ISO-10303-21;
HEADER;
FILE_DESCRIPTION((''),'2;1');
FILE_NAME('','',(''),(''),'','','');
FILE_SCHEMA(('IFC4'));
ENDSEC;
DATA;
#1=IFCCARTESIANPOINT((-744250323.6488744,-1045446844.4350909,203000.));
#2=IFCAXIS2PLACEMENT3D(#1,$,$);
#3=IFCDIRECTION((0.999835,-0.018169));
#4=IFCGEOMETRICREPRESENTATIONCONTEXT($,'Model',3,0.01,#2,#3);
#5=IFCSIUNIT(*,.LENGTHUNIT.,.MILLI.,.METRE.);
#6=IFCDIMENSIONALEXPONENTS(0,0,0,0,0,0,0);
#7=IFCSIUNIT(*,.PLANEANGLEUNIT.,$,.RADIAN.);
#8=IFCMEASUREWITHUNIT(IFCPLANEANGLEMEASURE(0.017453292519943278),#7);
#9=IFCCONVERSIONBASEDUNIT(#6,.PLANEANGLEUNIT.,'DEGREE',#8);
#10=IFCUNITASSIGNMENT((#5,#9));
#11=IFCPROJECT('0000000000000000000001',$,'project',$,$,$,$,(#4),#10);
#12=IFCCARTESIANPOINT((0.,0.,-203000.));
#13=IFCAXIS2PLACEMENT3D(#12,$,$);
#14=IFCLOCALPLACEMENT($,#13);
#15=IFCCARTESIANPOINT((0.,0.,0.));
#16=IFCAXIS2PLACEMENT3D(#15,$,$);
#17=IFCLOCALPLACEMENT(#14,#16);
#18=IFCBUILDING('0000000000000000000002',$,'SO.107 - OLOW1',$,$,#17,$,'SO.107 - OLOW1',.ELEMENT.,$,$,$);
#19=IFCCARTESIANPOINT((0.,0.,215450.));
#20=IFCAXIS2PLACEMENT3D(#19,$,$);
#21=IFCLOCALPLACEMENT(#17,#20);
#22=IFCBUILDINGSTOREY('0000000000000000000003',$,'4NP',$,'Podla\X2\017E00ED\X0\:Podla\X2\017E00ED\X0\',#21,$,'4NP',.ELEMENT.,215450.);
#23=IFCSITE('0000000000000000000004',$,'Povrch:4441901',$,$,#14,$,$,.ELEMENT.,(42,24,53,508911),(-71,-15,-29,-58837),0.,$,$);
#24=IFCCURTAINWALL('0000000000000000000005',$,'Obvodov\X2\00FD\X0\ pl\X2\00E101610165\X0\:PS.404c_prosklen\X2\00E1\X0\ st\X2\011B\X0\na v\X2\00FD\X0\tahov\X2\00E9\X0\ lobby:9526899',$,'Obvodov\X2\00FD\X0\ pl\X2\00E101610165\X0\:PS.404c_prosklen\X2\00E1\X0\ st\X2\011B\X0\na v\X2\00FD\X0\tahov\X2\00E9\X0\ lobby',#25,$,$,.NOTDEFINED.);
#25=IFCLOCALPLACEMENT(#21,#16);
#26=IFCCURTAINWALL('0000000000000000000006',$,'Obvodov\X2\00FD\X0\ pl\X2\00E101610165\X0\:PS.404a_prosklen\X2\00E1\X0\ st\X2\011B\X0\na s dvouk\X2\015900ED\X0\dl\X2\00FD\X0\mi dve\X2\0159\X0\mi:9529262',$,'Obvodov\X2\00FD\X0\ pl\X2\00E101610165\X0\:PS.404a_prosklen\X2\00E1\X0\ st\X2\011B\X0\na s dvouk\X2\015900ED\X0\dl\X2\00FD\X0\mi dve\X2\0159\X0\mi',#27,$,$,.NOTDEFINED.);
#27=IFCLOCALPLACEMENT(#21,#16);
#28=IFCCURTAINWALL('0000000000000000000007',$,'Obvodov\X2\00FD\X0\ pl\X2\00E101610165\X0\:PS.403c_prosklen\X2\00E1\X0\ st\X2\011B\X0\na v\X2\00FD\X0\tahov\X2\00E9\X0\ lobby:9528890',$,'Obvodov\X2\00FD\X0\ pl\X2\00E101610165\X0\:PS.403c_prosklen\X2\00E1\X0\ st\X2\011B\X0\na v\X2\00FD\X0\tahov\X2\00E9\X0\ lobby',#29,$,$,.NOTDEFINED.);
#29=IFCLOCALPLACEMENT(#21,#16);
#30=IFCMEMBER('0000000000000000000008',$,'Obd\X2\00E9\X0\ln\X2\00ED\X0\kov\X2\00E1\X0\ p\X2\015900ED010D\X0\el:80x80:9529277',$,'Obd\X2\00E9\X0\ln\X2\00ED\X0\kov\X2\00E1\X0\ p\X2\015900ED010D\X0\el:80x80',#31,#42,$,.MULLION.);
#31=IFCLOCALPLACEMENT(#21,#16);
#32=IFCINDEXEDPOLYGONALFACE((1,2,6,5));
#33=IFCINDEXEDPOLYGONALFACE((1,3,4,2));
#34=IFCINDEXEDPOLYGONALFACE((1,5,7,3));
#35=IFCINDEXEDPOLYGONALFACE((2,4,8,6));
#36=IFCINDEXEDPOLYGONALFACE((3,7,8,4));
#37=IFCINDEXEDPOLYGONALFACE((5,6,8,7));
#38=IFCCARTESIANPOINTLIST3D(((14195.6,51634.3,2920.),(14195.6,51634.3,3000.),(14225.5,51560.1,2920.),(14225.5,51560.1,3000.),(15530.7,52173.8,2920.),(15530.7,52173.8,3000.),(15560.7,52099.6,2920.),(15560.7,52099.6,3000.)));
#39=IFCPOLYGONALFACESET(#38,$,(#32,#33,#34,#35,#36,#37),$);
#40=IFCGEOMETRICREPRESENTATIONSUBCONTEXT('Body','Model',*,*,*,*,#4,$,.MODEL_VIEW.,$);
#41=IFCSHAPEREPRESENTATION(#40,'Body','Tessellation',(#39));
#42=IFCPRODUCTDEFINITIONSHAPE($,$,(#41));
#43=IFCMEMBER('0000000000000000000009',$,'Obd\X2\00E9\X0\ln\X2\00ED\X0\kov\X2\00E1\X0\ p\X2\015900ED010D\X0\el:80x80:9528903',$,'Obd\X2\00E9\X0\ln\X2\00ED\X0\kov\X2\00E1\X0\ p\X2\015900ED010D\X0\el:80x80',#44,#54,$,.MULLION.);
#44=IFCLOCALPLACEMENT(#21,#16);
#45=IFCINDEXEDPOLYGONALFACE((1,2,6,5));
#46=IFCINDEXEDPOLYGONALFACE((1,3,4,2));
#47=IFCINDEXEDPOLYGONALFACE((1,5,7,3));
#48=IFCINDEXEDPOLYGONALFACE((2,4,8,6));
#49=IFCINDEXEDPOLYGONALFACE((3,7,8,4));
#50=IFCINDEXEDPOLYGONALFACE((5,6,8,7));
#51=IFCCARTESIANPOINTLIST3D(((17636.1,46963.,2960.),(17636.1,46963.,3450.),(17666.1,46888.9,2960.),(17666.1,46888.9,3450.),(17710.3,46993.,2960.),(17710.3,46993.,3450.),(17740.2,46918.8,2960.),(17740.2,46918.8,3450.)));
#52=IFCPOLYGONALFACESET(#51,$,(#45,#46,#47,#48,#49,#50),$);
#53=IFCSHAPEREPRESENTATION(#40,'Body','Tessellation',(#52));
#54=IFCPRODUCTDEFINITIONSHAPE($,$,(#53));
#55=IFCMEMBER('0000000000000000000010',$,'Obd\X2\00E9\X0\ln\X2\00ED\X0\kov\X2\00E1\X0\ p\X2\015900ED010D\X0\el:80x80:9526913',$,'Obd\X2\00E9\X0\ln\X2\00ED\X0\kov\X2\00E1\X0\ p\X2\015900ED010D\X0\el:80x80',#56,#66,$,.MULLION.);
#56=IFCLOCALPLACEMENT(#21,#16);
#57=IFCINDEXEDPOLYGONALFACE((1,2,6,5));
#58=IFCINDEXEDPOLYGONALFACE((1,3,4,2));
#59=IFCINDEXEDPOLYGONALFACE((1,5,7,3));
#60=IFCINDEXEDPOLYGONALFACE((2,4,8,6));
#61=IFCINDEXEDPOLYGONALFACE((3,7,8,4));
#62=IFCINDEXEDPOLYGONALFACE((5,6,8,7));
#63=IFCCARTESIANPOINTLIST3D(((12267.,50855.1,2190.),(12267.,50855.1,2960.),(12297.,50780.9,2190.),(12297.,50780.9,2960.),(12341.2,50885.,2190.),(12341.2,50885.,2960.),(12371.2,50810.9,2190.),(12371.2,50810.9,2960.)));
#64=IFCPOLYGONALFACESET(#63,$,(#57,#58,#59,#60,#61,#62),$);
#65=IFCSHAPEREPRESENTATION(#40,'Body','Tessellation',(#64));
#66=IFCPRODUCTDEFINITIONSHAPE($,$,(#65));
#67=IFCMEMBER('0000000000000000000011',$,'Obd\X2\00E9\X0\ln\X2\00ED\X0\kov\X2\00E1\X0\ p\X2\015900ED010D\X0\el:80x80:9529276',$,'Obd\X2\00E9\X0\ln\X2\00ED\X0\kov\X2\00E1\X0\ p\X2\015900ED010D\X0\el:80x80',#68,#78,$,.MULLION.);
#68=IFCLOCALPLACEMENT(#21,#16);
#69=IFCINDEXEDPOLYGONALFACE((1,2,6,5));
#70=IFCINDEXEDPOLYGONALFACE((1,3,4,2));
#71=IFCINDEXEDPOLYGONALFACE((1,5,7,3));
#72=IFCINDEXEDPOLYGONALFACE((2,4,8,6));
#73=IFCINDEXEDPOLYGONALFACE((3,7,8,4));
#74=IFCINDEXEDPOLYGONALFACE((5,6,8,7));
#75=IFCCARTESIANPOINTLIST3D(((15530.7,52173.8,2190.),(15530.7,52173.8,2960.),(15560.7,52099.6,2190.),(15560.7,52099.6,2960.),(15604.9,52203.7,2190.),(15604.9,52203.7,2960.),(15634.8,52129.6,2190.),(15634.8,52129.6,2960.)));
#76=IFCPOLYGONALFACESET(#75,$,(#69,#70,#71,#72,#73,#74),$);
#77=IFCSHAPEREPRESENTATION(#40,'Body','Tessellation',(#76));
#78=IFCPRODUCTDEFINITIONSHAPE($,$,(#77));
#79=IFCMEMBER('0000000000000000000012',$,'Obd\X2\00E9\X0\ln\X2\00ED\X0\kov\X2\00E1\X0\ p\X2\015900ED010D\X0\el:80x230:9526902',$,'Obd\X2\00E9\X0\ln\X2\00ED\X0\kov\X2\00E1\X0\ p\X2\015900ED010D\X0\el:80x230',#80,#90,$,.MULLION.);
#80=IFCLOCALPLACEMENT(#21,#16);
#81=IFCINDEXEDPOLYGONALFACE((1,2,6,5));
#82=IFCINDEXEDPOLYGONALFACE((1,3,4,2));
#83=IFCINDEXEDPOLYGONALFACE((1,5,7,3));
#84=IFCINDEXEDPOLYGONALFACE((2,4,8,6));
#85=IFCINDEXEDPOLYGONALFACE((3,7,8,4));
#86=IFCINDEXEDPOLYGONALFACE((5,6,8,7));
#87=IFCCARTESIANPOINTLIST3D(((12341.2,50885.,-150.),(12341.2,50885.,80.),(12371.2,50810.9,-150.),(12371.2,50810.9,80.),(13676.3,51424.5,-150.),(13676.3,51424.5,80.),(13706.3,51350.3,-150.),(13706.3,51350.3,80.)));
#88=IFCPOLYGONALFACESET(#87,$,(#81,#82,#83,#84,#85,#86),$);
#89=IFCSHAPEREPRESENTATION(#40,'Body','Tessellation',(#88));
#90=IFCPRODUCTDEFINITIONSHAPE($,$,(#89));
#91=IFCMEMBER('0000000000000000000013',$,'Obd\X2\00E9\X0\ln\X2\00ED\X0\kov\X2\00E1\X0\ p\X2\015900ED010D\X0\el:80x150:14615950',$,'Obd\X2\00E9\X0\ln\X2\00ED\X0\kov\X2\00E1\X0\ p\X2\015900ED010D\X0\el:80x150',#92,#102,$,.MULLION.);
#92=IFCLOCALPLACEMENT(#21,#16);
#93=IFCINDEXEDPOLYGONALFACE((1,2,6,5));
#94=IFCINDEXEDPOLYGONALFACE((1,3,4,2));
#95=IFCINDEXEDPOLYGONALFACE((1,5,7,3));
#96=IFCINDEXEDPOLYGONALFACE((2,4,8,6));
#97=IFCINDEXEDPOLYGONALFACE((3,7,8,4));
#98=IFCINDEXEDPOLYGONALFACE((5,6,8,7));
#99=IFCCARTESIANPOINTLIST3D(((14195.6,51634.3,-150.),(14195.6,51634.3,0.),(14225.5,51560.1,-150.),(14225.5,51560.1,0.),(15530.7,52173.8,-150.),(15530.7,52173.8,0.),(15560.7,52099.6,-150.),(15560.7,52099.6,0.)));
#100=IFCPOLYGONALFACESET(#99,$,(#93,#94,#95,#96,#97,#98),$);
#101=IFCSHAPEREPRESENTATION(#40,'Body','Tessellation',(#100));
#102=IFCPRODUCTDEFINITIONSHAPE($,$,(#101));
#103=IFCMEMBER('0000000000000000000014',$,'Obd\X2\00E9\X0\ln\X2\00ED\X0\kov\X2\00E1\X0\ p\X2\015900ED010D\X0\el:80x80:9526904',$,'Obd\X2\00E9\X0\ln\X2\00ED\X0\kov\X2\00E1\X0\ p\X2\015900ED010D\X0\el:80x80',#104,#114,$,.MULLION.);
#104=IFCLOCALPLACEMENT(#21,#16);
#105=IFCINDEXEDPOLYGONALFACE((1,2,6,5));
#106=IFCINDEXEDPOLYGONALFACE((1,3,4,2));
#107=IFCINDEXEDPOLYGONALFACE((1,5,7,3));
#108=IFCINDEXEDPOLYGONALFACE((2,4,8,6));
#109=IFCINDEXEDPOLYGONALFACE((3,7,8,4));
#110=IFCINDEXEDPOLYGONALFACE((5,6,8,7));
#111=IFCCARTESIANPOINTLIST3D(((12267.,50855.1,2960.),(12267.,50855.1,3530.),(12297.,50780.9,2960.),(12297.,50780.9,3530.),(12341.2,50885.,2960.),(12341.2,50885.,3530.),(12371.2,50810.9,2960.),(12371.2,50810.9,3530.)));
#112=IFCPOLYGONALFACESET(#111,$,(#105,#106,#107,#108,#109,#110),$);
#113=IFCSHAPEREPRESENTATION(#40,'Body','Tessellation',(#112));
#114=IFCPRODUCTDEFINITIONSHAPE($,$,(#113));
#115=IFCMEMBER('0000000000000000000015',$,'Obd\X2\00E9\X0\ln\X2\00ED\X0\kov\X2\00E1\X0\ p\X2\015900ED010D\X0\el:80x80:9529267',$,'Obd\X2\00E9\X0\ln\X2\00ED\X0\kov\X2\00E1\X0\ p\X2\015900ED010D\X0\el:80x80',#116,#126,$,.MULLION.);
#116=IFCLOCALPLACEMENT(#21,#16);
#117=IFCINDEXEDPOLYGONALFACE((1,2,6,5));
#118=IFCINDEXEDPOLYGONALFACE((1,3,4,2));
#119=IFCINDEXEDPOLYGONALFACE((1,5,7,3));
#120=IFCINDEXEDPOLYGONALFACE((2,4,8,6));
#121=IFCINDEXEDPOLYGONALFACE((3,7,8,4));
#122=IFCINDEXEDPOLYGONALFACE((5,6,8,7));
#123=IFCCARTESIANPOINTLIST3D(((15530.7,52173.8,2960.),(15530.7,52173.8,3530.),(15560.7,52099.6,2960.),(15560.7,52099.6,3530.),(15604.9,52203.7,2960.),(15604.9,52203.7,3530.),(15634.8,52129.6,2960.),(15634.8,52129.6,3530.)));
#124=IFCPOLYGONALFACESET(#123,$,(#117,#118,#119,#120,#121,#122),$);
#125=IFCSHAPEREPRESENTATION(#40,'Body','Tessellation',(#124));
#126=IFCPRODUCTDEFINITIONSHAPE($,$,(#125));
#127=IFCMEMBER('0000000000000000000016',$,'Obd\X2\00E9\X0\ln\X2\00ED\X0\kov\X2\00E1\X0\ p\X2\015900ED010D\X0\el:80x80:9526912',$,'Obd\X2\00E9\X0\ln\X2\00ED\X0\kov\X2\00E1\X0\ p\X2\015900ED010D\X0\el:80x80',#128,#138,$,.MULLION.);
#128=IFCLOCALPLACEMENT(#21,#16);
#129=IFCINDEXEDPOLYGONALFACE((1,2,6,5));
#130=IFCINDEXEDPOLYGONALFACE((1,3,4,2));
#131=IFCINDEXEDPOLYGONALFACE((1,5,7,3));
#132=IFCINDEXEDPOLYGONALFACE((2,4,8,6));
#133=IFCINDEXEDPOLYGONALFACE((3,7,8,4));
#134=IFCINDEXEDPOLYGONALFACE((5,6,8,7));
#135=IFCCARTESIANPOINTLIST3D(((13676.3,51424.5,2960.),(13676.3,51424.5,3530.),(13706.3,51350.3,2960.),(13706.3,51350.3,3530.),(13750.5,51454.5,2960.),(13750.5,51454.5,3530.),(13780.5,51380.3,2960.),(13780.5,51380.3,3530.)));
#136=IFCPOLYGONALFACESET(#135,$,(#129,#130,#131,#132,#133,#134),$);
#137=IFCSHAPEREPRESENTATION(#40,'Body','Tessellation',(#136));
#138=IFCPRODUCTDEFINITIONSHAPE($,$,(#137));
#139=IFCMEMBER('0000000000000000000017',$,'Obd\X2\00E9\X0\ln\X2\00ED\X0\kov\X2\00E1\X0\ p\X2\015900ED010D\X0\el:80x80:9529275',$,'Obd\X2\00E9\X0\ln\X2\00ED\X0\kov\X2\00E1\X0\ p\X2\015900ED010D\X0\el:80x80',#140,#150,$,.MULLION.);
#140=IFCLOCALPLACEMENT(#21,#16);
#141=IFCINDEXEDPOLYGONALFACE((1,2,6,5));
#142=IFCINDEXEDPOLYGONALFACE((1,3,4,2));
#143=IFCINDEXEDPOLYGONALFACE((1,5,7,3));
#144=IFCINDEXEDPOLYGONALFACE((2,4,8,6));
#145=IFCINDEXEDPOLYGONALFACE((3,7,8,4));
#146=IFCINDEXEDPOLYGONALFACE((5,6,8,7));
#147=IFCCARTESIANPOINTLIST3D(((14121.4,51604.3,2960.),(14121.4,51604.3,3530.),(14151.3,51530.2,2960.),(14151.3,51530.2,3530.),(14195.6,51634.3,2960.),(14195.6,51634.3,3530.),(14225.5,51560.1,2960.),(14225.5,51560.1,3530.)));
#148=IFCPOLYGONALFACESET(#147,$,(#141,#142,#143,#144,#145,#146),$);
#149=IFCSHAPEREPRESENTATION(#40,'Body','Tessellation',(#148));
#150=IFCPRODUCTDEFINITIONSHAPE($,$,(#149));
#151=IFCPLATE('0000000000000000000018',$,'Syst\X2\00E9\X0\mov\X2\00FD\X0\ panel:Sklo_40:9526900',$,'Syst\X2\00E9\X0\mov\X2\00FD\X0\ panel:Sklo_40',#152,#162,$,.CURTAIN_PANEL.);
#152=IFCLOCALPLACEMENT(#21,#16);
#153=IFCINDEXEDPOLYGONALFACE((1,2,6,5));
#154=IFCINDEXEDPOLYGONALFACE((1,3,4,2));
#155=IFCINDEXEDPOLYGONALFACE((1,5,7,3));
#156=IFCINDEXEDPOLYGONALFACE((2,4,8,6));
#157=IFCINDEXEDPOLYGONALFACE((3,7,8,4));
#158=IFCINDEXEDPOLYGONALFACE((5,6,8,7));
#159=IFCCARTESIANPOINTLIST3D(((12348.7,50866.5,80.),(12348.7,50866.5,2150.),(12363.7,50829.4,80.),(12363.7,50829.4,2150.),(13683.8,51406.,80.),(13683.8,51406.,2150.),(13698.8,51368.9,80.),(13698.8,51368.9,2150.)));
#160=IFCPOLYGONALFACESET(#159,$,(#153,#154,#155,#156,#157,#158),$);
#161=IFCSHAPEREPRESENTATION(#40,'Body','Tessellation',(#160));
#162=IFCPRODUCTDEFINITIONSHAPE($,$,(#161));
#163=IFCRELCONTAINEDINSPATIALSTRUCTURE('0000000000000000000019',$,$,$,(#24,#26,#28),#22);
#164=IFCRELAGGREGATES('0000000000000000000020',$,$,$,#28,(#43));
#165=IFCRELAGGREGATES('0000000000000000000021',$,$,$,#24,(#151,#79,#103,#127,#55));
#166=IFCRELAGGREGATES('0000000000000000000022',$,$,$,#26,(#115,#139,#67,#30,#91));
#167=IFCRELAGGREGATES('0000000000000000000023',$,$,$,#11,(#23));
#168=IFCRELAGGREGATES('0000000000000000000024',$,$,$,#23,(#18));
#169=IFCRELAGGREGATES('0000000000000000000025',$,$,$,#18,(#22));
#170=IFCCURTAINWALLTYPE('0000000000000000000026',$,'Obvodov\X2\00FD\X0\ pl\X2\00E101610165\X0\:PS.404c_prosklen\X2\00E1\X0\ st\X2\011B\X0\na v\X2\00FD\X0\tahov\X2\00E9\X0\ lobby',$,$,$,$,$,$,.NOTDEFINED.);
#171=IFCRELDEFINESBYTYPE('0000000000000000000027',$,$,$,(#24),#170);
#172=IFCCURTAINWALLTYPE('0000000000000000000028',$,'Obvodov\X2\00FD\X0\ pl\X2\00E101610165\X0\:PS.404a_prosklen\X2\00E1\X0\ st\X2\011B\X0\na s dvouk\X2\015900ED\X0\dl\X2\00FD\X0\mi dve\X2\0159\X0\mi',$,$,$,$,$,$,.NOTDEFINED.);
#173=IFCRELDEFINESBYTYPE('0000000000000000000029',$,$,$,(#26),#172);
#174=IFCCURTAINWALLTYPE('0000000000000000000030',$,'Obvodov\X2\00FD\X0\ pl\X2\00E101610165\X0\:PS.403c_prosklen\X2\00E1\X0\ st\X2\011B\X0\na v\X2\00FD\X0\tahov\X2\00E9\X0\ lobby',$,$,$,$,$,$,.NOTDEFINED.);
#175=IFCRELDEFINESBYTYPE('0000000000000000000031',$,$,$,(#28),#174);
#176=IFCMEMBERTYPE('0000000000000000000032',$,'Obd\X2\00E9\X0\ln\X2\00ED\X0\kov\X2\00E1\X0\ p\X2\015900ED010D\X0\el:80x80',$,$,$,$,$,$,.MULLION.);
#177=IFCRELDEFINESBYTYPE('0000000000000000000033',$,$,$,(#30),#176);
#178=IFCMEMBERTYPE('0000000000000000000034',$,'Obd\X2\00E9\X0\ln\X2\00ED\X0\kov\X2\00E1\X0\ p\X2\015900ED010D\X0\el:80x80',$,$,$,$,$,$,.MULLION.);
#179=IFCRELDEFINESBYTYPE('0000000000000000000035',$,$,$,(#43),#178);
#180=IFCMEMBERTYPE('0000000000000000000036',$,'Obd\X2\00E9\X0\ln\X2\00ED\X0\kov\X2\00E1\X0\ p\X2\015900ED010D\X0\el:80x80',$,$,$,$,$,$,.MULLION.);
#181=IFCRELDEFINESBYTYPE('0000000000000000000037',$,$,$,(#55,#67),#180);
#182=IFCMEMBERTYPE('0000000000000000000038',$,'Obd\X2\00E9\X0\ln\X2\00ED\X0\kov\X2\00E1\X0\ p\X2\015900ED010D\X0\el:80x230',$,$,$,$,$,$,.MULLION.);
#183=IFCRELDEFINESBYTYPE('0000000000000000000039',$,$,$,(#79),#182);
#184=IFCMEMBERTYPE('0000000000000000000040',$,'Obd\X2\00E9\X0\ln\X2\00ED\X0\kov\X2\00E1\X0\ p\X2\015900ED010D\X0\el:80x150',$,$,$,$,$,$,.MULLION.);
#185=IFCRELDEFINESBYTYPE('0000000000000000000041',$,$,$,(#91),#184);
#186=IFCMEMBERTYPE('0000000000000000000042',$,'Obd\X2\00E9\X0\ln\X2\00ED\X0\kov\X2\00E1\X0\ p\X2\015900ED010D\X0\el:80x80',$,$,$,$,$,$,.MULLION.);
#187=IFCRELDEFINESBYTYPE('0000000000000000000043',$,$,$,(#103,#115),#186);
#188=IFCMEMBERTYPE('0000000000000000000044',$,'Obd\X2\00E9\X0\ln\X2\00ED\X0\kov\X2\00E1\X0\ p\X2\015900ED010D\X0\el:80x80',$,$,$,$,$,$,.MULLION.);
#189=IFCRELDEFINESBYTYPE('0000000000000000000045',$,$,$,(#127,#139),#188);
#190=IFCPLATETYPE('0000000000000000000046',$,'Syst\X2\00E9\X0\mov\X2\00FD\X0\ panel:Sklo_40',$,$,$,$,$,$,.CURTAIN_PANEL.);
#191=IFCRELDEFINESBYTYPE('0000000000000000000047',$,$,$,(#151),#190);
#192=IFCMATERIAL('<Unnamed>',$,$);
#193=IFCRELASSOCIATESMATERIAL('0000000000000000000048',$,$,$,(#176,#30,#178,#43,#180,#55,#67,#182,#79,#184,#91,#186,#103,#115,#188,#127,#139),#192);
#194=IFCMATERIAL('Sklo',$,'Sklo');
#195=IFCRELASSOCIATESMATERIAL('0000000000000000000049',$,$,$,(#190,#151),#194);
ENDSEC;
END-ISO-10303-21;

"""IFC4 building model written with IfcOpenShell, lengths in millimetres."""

from ifc_helpers import new_model, entity, si_unit, converted_unit, direction, frame, origin, place, context, subcontext, project, spatial, indexed_curve, outline, extrude, source, transform, mapped, material, type_object, type_shapes, element, aggregate, save


model = new_model("IFC4")

# Units and contexts
model_context = context("Model", 3, precision=0.01, world=frame((-744250323.6488744, -1045446844.4350909, 203000.0)), true_north=direction((0.999835, -0.018169)))
body_context = subcontext(model_context, "Body", "Model", "MODEL_VIEW")
ifc_project = project(units=[si_unit("LENGTHUNIT", "METRE", prefix="MILLI"), converted_unit("PLANEANGLEUNIT", "DEGREE", entity("IfcPlaneAngleMeasure", 0.017453292519943278), si_unit("PLANEANGLEUNIT", "RADIAN"), dimensions=[0, 0, 0, 0, 0, 0, 0])], contexts=[model_context])

# Site, building, storey
site_placement = place(None, frame((0.0, 0.0, -203000.0)))
site = spatial("IfcSite", under=ifc_project, at=site_placement, Name="Povrch:4441901", CompositionType="ELEMENT", RefLatitude=(42, 24, 53, 508911), RefLongitude=(-71, -15, -29, -58837), RefElevation=0.0)
building_placement = place(site_placement, origin())
building = spatial("IfcBuilding", under=site, at=building_placement, Name="SO.107 - OLOW1", LongName="SO.107 - OLOW1", CompositionType="ELEMENT")
storey_placement = place(building_placement, frame((0.0, 0.0, 215450.0)))
storey = spatial("IfcBuildingStorey", under=building, at=storey_placement, Name="4NP", ObjectType="Podlaží:Podlaží", LongName="4NP", CompositionType="ELEMENT", Elevation=215450.0)

# Curtain walls
curtain_wall_type_1 = type_object("IfcCurtainWallType", Name="Obvodový plášť:PS.404c_prosklená stěna výtahové lobby", PredefinedType="NOTDEFINED")
curtain_wall_1_placement = place(storey_placement, frame((0.0, 0.0, -215450.0)))
curtain_wall_1 = element("IfcCurtainWall", 1, at=curtain_wall_1_placement, inside=storey, type_object=curtain_wall_type_1, Name="Obvodový plášť:PS.404c_prosklená stěna výtahové lobby:9526899", ObjectType="Obvodový plášť:PS.404c_prosklená stěna výtahové lobby", PredefinedType="NOTDEFINED")
ifc_material_1 = material(Name="<Unnamed>")
curtain_wall_type_2 = type_object("IfcCurtainWallType", Name="Obvodový plášť:PS.404a_prosklená stěna s dvoukřídlými dveřmi", PredefinedType="NOTDEFINED")
curtain_wall_2_placement = place(storey_placement, frame((0.0, 0.0, -215450.0)))
curtain_wall_2 = element("IfcCurtainWall", 2, at=curtain_wall_2_placement, inside=storey, type_object=curtain_wall_type_2, Name="Obvodový plášť:PS.404a_prosklená stěna s dvoukřídlými dveřmi:9529262", ObjectType="Obvodový plášť:PS.404a_prosklená stěna s dvoukřídlými dveřmi", PredefinedType="NOTDEFINED")

# Curtain wall
curtain_wall_type_3 = type_object("IfcCurtainWallType", Name="Obvodový plášť:PS.403c_prosklená stěna výtahové lobby", PredefinedType="NOTDEFINED")
curtain_wall_3_placement = place(storey_placement, frame((0.0, 0.0, -215450.0)))
curtain_wall_3 = element("IfcCurtainWall", 3, at=curtain_wall_3_placement, inside=storey, type_object=curtain_wall_type_3, Name="Obvodový plášť:PS.403c_prosklená stěna výtahové lobby:9528890", ObjectType="Obvodový plášť:PS.403c_prosklená stěna výtahové lobby", PredefinedType="NOTDEFINED")

# Members
member_type_1 = type_object("IfcMemberType", Name="Obdélníková příčel:80x80", PredefinedType="MULLION", material=ifc_material_1)
shared_shape_1 = source(origin(), body_context, "Body", "SweptSolid", [
    extrude(outline(indexed_curve([(-40.0, -40.0), (40.0, -40.0), (40.0, 40.0), (-40.0, 40.0), (-40.0, -40.0)], self_intersect=False)), frame((0.0, 0.0, -1440.0), z_axis=(0.0, 0.0, 1.0), x_axis=(-1.0, 0.0, 0.0)), (0.0, 0.0, 1.0), 1440.0),
])
type_shapes(member_type_1, [shared_shape_1])
member_1_placement = place(curtain_wall_2_placement, frame((14210.5, 51597.2, 218410.0), z_axis=(-0.927176, -0.374626, 0.0), x_axis=(0.0, 0.0, 1.0)))
member_1 = element("IfcMember", 4, at=member_1_placement, type_object=member_type_1, material=ifc_material_1, Name="Obdélníková příčel:80x80:9529277", ObjectType="Obdélníková příčel:80x80", PredefinedType="MULLION", context=body_context, shape_type="MappedRepresentation", body=[
    mapped(shared_shape_1, transform((0.0, 0.0, 0.0), scale=1.0)),
])
member_type_2 = type_object("IfcMemberType", Name="Obdélníková příčel:80x80", PredefinedType="MULLION", material=ifc_material_1)
shared_shape_2 = source(origin(), body_context, "Body", "SweptSolid", [
    extrude(outline(indexed_curve([(-40.0, -40.0), (40.0, -40.0), (40.0, 40.0), (-40.0, 40.0), (-40.0, -40.0)], self_intersect=False)), frame((-40.0, 0.0, -490.0), z_axis=(0.0, 0.0, 1.0), x_axis=(-1.0, 0.0, 0.0)), (0.0, 0.0, 1.0), 490.0),
])
type_shapes(member_type_2, [shared_shape_2])
member_2_placement = place(curtain_wall_3_placement, frame((17725.2, 46955.9, 218410.0), z_axis=(0.0, 0.0, -1.0), x_axis=(0.927176, 0.374626, 0.0)))
member_2 = element("IfcMember", 5, at=member_2_placement, type_object=member_type_2, material=ifc_material_1, Name="Obdélníková příčel:80x80:9528903", ObjectType="Obdélníková příčel:80x80", PredefinedType="MULLION", context=body_context, shape_type="MappedRepresentation", body=[
    mapped(shared_shape_2, transform((0.0, 0.0, 0.0), scale=1.0)),
])
aggregate(curtain_wall_3, [member_2])
member_type_3 = type_object("IfcMemberType", Name="Obdélníková příčel:80x80", PredefinedType="MULLION", material=ifc_material_1)
shared_shape_3 = source(origin(), body_context, "Body", "SweptSolid", [
    extrude(outline(indexed_curve([(-40.0, -40.0), (40.0, -40.0), (40.0, 40.0), (-40.0, 40.0), (-40.0, -40.0)], self_intersect=False)), frame((-40.0, 0.0, -770.0), z_axis=(0.0, 0.0, 1.0), x_axis=(-1.0, 0.0, 0.0)), (0.0, 0.0, 1.0), 770.0),
])
type_shapes(member_type_3, [shared_shape_3])
member_3_placement = place(curtain_wall_1_placement, frame((12282.0, 50818.0, 218410.0), z_axis=(0.0, 0.0, 1.0), x_axis=(-0.927176, -0.374626, 0.0)))
member_3 = element("IfcMember", 6, at=member_3_placement, type_object=member_type_3, material=ifc_material_1, Name="Obdélníková příčel:80x80:9526913", ObjectType="Obdélníková příčel:80x80", PredefinedType="MULLION", context=body_context, shape_type="MappedRepresentation", body=[
    mapped(shared_shape_3, transform((0.0, 0.0, 0.0), scale=1.0)),
])
member_4_placement = place(curtain_wall_2_placement, frame((15619.8, 52166.6, 218410.0), z_axis=(0.0, 0.0, 1.0), x_axis=(0.927176, 0.374626, 0.0)))
member_4 = element("IfcMember", 7, at=member_4_placement, type_object=member_type_3, material=ifc_material_1, Name="Obdélníková příčel:80x80:9529276", ObjectType="Obdélníková příčel:80x80", PredefinedType="MULLION", context=body_context, shape_type="MappedRepresentation", body=[
    mapped(shared_shape_3, transform((0.0, 0.0, 0.0), scale=1.0)),
])
member_type_4 = type_object("IfcMemberType", Name="Obdélníková příčel:80x230", PredefinedType="MULLION", material=ifc_material_1)
shared_shape_4 = source(origin(), body_context, "Body", "SweptSolid", [
    extrude(outline(indexed_curve([(-115.0, -40.0), (115.0, -40.0), (115.0, 40.0), (-115.0, 40.0), (-115.0, -40.0)], self_intersect=False)), frame((-115.0, 0.0, -1440.0), z_axis=(0.0, 0.0, 1.0), x_axis=(-1.0, 0.0, 0.0)), (0.0, 0.0, 1.0), 1440.0),
])
type_shapes(member_type_4, [shared_shape_4])
member_5_placement = place(curtain_wall_1_placement, frame((12356.2, 50848.0, 215300.0), z_axis=(-0.927176, -0.374626, 0.0), x_axis=(0.0, 0.0, -1.0)))
member_5 = element("IfcMember", 8, at=member_5_placement, type_object=member_type_4, material=ifc_material_1, Name="Obdélníková příčel:80x230:9526902", ObjectType="Obdélníková příčel:80x230", PredefinedType="MULLION", context=body_context, shape_type="MappedRepresentation", body=[
    mapped(shared_shape_4, transform((0.0, 0.0, 0.0), scale=1.0)),
])
member_type_5 = type_object("IfcMemberType", Name="Obdélníková příčel:80x150", PredefinedType="MULLION", material=ifc_material_1)
shared_shape_5 = source(origin(), body_context, "Body", "SweptSolid", [
    extrude(outline(indexed_curve([(-75.0, -40.0), (75.0, -40.0), (75.0, 40.0), (-75.0, 40.0), (-75.0, -40.0)], self_intersect=False)), frame((-75.0, 0.0, -1440.0), z_axis=(0.0, 0.0, 1.0), x_axis=(-1.0, 0.0, 0.0)), (0.0, 0.0, 1.0), 1440.0),
])
type_shapes(member_type_5, [shared_shape_5])
member_6_placement = place(curtain_wall_2_placement, frame((15545.7, 52136.7, 215300.0), z_axis=(0.927176, 0.374626, 0.0), x_axis=(0.0, 0.0, -1.0)))
member_6 = element("IfcMember", 9, at=member_6_placement, type_object=member_type_5, material=ifc_material_1, Name="Obdélníková příčel:80x150:14615950", ObjectType="Obdélníková příčel:80x150", PredefinedType="MULLION", context=body_context, shape_type="MappedRepresentation", body=[
    mapped(shared_shape_5, transform((0.0, 0.0, 0.0), scale=1.0)),
])
member_type_6 = type_object("IfcMemberType", Name="Obdélníková příčel:80x80", PredefinedType="MULLION", material=ifc_material_1)
shared_shape_6 = source(origin(), body_context, "Body", "SweptSolid", [
    extrude(outline(indexed_curve([(-40.0, -40.0), (40.0, -40.0), (40.0, 40.0), (-40.0, 40.0), (-40.0, -40.0)], self_intersect=False)), frame((-40.0, 0.0, -570.0), z_axis=(0.0, 0.0, 1.0), x_axis=(-1.0, 0.0, 0.0)), (0.0, 0.0, 1.0), 570.0),
])
type_shapes(member_type_6, [shared_shape_6])
member_7_placement = place(curtain_wall_1_placement, frame((12282.0, 50818.0, 218980.0), z_axis=(0.0, 0.0, 1.0), x_axis=(-0.927176, -0.374626, 0.0)))
member_7 = element("IfcMember", 10, at=member_7_placement, type_object=member_type_6, material=ifc_material_1, Name="Obdélníková příčel:80x80:9526904", ObjectType="Obdélníková příčel:80x80", PredefinedType="MULLION", context=body_context, shape_type="MappedRepresentation", body=[
    mapped(shared_shape_6, transform((0.0, 0.0, 0.0), scale=1.0)),
])
member_8_placement = place(curtain_wall_2_placement, frame((15619.8, 52166.6, 218980.0), z_axis=(0.0, 0.0, 1.0), x_axis=(0.927176, 0.374626, 0.0)))
member_8 = element("IfcMember", 11, at=member_8_placement, type_object=member_type_6, material=ifc_material_1, Name="Obdélníková příčel:80x80:9529267", ObjectType="Obdélníková příčel:80x80", PredefinedType="MULLION", context=body_context, shape_type="MappedRepresentation", body=[
    mapped(shared_shape_6, transform((0.0, 0.0, 0.0), scale=1.0)),
])
member_type_7 = type_object("IfcMemberType", Name="Obdélníková příčel:80x80", PredefinedType="MULLION", material=ifc_material_1)
shared_shape_7 = source(origin(), body_context, "Body", "SweptSolid", [
    extrude(outline(indexed_curve([(-40.0, -40.0), (40.0, -40.0), (40.0, 40.0), (-40.0, 40.0), (-40.0, -40.0)], self_intersect=False)), frame((-40.0, 0.0, -570.0), z_axis=(0.0, 0.0, 1.0), x_axis=(-1.0, 0.0, 0.0)), (0.0, 0.0, 1.0), 570.0),
])
type_shapes(member_type_7, [shared_shape_7])
member_9_placement = place(curtain_wall_1_placement, frame((13765.5, 51417.4, 218410.0), z_axis=(0.0, 0.0, -1.0), x_axis=(0.927176, 0.374626, 0.0)))
member_9 = element("IfcMember", 12, at=member_9_placement, type_object=member_type_7, material=ifc_material_1, Name="Obdélníková příčel:80x80:9526912", ObjectType="Obdélníková příčel:80x80", PredefinedType="MULLION", context=body_context, shape_type="MappedRepresentation", body=[
    mapped(shared_shape_7, transform((0.0, 0.0, 0.0), scale=1.0)),
])
member_10_placement = place(curtain_wall_2_placement, frame((14136.4, 51567.2, 218410.0), z_axis=(0.0, 0.0, -1.0), x_axis=(-0.927176, -0.374626, 0.0)))
member_10 = element("IfcMember", 13, at=member_10_placement, type_object=member_type_7, material=ifc_material_1, Name="Obdélníková příčel:80x80:9529275", ObjectType="Obdélníková příčel:80x80", PredefinedType="MULLION", context=body_context, shape_type="MappedRepresentation", body=[
    mapped(shared_shape_7, transform((0.0, 0.0, 0.0), scale=1.0)),
])

# Plate
ifc_material_2 = material(Name="Sklo", Category="Sklo")
plate_type_1 = type_object("IfcPlateType", Name="Systémový panel:Sklo_40", PredefinedType="CURTAIN_PANEL", material=ifc_material_2)
shared_shape_8 = source(origin(), body_context, "Body", "SweptSolid", [
    extrude(outline(indexed_curve([(-20.0, -720.0), (20.0, -720.0), (20.0, 720.0), (-20.0, 720.0), (-20.0, -720.0)], self_intersect=False)), frame((0.0, 0.0, 0.0), z_axis=(0.0, 0.0, 1.0), x_axis=(0.0, 1.0, 0.0)), (0.0, 0.0, 1.0), 2070.0),
])
type_shapes(plate_type_1, [shared_shape_8])
plate_1_placement = place(curtain_wall_1_placement, frame((13023.8, 51117.7, 215530.0), z_axis=(0.0, 0.0, 1.0), x_axis=(0.927176, 0.374626, 0.0)))
plate_1 = element("IfcPlate", 14, at=plate_1_placement, type_object=plate_type_1, material=ifc_material_2, Name="Systémový panel:Sklo_40:9526900", ObjectType="Systémový panel:Sklo_40", PredefinedType="CURTAIN_PANEL", context=body_context, shape_type="MappedRepresentation", body=[
    mapped(shared_shape_8, transform((0.0, 0.0, 0.0), scale=1.0)),
])
aggregate(curtain_wall_1, [plate_1, member_5, member_7, member_9, member_3])

aggregate(curtain_wall_2, [member_8, member_10, member_4, member_1, member_6])

save(model, "model.ifc")
